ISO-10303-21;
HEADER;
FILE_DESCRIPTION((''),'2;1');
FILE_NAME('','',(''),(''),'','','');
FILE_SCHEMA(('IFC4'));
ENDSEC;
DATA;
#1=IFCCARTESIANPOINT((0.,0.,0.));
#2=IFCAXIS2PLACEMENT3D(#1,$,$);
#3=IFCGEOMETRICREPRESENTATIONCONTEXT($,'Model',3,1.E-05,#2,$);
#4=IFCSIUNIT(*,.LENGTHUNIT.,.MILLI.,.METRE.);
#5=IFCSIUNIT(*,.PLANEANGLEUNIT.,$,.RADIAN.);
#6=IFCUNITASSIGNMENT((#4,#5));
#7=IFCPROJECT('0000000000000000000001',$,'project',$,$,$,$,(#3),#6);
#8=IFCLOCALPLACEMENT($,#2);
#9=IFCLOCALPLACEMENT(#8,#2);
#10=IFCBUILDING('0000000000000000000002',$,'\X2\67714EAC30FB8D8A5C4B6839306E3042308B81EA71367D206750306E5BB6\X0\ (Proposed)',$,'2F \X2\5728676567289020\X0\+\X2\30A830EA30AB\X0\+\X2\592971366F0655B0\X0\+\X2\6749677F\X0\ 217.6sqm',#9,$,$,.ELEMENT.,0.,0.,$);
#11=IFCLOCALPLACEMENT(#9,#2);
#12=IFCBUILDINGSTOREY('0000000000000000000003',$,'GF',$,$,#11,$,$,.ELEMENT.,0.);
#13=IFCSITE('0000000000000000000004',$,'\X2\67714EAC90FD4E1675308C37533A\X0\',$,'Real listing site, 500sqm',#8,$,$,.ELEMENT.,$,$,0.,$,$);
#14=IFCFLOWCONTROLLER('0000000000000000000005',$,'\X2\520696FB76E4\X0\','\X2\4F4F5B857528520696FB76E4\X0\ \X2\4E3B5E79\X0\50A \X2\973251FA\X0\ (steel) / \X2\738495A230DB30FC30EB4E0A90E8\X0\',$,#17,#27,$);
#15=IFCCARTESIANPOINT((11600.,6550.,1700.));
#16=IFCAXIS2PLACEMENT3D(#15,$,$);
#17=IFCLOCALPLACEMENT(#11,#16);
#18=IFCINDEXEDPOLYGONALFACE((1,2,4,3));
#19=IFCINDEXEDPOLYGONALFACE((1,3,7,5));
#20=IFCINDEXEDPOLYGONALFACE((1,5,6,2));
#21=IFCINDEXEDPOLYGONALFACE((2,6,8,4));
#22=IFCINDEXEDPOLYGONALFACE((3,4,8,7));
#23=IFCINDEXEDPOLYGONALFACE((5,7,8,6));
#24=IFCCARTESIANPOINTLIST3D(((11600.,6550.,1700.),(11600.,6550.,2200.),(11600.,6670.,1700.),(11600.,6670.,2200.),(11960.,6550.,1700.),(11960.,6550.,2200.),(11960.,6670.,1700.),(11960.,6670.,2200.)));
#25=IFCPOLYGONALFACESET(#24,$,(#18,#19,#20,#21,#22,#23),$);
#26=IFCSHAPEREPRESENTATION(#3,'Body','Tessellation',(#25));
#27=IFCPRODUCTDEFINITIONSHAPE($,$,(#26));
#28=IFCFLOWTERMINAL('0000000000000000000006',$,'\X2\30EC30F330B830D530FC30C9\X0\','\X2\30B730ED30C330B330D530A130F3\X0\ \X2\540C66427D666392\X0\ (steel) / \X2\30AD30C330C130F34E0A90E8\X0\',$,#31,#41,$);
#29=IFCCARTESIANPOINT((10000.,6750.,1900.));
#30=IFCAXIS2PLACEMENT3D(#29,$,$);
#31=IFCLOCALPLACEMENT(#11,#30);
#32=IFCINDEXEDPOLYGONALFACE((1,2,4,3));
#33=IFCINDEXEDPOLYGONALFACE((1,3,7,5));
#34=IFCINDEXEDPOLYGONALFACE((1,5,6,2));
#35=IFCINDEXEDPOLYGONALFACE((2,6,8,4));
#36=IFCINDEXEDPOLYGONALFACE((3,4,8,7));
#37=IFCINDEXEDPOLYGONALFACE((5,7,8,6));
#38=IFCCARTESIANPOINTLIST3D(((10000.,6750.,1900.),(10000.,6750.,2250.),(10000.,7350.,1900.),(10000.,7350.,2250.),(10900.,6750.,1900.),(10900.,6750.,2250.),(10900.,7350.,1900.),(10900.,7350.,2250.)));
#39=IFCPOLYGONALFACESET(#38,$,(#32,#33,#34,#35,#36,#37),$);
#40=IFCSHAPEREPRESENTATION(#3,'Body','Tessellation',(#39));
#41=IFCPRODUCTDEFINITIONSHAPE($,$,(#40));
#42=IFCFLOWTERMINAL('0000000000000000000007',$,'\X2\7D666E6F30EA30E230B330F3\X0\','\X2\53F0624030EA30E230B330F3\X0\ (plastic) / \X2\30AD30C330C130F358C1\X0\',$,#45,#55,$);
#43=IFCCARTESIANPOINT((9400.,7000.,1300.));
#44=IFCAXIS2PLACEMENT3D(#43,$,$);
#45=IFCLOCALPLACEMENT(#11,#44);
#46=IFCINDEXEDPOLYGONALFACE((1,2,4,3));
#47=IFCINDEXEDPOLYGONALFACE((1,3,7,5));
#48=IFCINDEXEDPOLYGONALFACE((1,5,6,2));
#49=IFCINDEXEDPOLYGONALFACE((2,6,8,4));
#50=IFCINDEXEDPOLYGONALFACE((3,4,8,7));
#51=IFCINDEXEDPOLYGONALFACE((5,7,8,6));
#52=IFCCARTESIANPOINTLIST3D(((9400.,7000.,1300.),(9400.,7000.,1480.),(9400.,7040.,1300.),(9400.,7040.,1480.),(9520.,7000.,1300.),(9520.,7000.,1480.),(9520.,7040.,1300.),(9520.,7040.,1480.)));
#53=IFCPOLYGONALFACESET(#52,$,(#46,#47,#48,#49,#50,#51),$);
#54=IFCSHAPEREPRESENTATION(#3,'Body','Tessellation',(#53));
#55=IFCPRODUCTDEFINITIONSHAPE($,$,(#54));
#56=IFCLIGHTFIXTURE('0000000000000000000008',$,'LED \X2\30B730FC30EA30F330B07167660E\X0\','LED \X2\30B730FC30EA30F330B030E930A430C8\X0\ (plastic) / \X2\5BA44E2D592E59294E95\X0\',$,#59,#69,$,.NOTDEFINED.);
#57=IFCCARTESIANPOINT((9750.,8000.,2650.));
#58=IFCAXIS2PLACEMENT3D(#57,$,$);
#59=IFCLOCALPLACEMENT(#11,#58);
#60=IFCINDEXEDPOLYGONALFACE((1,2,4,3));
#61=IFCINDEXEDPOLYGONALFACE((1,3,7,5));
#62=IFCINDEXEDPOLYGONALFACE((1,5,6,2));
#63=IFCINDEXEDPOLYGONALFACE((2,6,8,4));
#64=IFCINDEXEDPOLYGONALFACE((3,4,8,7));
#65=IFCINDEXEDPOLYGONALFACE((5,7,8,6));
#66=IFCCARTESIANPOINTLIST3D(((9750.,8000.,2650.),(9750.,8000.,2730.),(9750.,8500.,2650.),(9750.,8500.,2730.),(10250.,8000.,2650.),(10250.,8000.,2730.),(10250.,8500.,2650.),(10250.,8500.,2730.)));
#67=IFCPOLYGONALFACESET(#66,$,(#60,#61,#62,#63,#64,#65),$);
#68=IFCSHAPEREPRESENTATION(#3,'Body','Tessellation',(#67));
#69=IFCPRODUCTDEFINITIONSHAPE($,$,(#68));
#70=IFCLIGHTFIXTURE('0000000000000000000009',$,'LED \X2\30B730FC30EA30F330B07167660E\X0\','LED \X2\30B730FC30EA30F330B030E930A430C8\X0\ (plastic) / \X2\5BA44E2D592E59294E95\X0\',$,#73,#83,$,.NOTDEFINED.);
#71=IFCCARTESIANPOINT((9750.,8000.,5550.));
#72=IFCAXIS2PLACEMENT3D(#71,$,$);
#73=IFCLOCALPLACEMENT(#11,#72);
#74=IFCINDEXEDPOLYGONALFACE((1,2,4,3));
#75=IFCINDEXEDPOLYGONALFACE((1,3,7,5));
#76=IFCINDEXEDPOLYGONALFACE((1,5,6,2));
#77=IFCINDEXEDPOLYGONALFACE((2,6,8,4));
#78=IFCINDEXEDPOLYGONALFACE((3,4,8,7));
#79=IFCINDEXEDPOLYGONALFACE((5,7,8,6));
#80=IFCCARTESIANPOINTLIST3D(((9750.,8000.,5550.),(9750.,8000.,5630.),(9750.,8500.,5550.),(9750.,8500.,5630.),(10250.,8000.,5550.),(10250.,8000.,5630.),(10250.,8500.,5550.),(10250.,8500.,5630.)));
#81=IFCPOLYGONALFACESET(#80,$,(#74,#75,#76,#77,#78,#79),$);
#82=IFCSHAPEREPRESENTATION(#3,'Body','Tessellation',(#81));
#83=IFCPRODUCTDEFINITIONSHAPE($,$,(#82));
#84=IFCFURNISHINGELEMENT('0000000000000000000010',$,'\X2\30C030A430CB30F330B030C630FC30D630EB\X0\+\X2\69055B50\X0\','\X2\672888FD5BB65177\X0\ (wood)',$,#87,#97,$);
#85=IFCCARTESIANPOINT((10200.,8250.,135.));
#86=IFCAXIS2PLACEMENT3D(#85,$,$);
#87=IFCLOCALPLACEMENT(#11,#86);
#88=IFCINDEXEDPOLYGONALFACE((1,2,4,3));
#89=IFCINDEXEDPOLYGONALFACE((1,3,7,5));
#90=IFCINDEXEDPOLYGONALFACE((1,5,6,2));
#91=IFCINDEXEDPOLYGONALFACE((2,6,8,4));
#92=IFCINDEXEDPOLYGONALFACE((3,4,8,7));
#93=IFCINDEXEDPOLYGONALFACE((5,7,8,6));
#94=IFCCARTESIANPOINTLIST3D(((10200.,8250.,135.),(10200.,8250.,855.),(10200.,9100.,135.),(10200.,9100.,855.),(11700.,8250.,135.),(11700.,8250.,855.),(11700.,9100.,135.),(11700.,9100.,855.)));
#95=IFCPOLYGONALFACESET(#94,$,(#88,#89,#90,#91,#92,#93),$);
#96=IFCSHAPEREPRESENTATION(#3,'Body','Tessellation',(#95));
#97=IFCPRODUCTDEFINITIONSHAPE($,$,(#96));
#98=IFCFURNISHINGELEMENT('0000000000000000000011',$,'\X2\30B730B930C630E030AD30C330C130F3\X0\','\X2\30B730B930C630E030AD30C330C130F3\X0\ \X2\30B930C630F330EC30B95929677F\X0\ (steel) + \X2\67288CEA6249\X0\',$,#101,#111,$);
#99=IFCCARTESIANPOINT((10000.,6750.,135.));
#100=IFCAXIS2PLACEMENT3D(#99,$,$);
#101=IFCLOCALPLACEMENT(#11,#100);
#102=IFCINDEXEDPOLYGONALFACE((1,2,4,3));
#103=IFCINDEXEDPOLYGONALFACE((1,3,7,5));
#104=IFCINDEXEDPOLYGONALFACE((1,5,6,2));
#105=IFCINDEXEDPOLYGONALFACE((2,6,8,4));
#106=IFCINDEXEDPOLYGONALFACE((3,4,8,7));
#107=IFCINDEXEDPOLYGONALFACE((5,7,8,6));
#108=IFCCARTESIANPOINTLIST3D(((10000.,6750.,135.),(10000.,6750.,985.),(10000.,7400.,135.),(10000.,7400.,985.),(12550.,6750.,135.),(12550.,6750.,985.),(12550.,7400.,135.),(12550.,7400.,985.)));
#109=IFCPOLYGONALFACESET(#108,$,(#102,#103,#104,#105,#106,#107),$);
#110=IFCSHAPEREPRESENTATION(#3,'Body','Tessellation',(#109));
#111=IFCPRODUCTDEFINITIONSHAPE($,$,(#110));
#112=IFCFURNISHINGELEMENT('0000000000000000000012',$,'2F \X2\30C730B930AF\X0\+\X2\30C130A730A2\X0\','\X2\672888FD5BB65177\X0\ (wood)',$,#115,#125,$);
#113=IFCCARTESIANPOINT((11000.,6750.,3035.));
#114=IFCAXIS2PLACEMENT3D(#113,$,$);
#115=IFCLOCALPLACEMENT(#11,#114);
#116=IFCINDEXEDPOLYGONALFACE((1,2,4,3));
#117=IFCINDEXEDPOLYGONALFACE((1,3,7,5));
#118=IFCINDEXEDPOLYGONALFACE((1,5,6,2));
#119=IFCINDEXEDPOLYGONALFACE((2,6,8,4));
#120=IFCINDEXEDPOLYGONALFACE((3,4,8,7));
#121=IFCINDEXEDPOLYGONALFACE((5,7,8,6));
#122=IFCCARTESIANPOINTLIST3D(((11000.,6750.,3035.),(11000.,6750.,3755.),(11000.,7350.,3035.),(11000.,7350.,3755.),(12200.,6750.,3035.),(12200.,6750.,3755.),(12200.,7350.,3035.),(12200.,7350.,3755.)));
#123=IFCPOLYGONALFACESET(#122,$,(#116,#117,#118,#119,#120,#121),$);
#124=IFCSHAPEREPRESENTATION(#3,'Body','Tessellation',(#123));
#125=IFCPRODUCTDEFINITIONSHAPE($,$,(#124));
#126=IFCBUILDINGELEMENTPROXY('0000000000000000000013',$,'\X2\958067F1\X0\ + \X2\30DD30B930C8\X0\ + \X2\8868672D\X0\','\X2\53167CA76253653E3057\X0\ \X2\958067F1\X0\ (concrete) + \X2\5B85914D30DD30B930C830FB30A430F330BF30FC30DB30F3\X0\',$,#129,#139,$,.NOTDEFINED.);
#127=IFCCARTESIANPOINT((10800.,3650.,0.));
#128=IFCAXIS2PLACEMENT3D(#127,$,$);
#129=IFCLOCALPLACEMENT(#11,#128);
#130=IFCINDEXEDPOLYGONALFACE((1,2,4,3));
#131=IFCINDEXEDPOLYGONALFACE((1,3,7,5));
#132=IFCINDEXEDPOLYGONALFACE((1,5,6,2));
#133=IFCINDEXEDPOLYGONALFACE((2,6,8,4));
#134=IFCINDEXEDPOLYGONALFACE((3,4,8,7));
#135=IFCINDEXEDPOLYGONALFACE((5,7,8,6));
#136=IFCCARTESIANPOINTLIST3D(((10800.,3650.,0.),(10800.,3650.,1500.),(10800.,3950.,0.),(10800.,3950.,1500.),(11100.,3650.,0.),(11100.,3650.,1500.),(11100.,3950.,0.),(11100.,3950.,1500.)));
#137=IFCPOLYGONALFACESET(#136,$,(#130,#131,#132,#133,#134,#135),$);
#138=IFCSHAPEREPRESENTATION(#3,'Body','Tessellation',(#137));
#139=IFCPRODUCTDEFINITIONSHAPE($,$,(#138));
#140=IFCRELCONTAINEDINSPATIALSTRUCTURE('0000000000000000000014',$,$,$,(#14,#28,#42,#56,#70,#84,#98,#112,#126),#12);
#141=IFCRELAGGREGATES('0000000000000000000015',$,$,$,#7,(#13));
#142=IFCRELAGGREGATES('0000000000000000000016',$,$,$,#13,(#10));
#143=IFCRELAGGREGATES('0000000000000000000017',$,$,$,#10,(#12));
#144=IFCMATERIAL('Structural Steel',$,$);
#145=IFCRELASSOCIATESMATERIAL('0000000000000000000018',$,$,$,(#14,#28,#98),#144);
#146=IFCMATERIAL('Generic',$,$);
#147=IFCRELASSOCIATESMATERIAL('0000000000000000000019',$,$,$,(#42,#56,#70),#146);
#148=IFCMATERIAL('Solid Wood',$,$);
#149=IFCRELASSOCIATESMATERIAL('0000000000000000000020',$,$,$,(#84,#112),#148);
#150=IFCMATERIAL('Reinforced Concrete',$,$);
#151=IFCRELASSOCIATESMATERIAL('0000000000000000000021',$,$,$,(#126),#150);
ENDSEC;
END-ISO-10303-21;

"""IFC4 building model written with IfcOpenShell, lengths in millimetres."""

from ifc_helpers import new_model, si_unit, frame, frame_2d, origin, place, context, project, spatial, rectangle, extrude, material, element, save


model = new_model("IFC4")

# Units and contexts
model_context = context("Model", 3, precision=1e-05, world=origin())
ifc_project = project(units=[si_unit("LENGTHUNIT", "METRE", prefix="MILLI"), si_unit("PLANEANGLEUNIT", "RADIAN")], contexts=[model_context])

# Site, building, storey
site_placement = place(None, origin())
site = spatial("IfcSite", under=ifc_project, at=site_placement, Name="東京都世田谷区", ObjectType="Real listing site, 500sqm", CompositionType="ELEMENT", RefElevation=0.0)
building_placement = place(site_placement, origin())
building = spatial("IfcBuilding", under=site, at=building_placement, Name="東京・越屋根のある自然素材の家 (Proposed)", ObjectType="2F 在来木造+エリカ+天然漆喰+杉板 217.6sqm", CompositionType="ELEMENT", ElevationOfRefHeight=0.0, ElevationOfTerrain=0.0)
storey_placement = place(building_placement, origin())
storey = spatial("IfcBuildingStorey", under=building, at=storey_placement, Name="GF", CompositionType="ELEMENT", Elevation=0.0)

# Shared definitions
ifc_material_1 = material(Name="Solid Wood")

# Shared definitions
ifc_material_2 = material(Name="Structural Steel")

# Shared definitions
ifc_material_3 = material(Name="Reinforced Concrete")

# Flow controller
flow_controller_placement = place(storey_placement, frame((11600.0, 6550.0, 1700.0)))
element("IfcFlowController", 1, at=flow_controller_placement, inside=storey, material=ifc_material_2, Name="分電盤", Description="住宅用分電盤 主幹50A 露出 (steel) / 玄関ホール上部", context=model_context, shape_type="SweptSolid", body=[
    extrude(rectangle(XDim=360.0, YDim=120.0, at=frame_2d((180.0, 60.0))), frame((11600.0, 6550.0, 1700.0)), (0.0, 0.0, 1.0), 500.0),
])

# Flow terminals
flow_terminal_1_placement = place(storey_placement, frame((10000.0, 6750.0, 1900.0)))
element("IfcFlowTerminal", 2, at=flow_terminal_1_placement, inside=storey, material=ifc_material_2, Name="レンジフード", Description="シロッコファン 同時給排 (steel) / キッチン上部", context=model_context, shape_type="SweptSolid", body=[
    extrude(rectangle(XDim=900.0, YDim=600.0, at=frame_2d((450.0, 300.0))), frame((10000.0, 6750.0, 1900.0)), (0.0, 0.0, 1.0), 350.0),
])
ifc_material_4 = material(Name="Generic")
flow_terminal_2_placement = place(storey_placement, frame((9400.0, 7000.0, 1300.0)))
element("IfcFlowTerminal", 3, at=flow_terminal_2_placement, inside=storey, material=ifc_material_4, Name="給湯リモコン", Description="台所リモコン (plastic) / キッチン壁", context=model_context, shape_type="SweptSolid", body=[
    extrude(rectangle(XDim=120.0, YDim=40.0, at=frame_2d((60.0, 20.0))), frame((9400.0, 7000.0, 1300.0)), (0.0, 0.0, 1.0), 180.0),
])

# Light fixtures
light_fixture_1_placement = place(storey_placement, frame((9750.0, 8000.0, 2650.0)))
element("IfcLightFixture", 4, at=light_fixture_1_placement, inside=storey, material=ifc_material_4, Name="LED シーリング照明", Description="LED シーリングライト (plastic) / 室中央天井", PredefinedType="NOTDEFINED", context=model_context, shape_type="SweptSolid", body=[
    extrude(rectangle(XDim=500.0, YDim=500.0, at=frame_2d((250.0, 250.0))), frame((9750.0, 8000.0, 2650.0)), (0.0, 0.0, 1.0), 80.0),
])
light_fixture_2_placement = place(storey_placement, frame((9750.0, 8000.0, 5550.0)))
element("IfcLightFixture", 5, at=light_fixture_2_placement, inside=storey, material=ifc_material_4, Name="LED シーリング照明", Description="LED シーリングライト (plastic) / 室中央天井", PredefinedType="NOTDEFINED", context=model_context, shape_type="SweptSolid", body=[
    extrude(rectangle(XDim=500.0, YDim=500.0, at=frame_2d((250.0, 250.0))), frame((9750.0, 8000.0, 5550.0)), (0.0, 0.0, 1.0), 80.0),
])

# Furnishing elements
furnishing_1_placement = place(storey_placement, frame((10200.0, 8250.0, 135.0)))
element("IfcFurnishingElement", 6, at=furnishing_1_placement, inside=storey, material=ifc_material_1, Name="ダイニングテーブル+椅子", Description="木製家具 (wood)", context=model_context, shape_type="SweptSolid", body=[
    extrude(rectangle(XDim=1500.0, YDim=850.0, at=frame_2d((750.0, 425.0))), frame((10200.0, 8250.0, 135.0)), (0.0, 0.0, 1.0), 720.0),
])
furnishing_2_placement = place(storey_placement, frame((10000.0, 6750.0, 135.0)))
element("IfcFurnishingElement", 7, at=furnishing_2_placement, inside=storey, material=ifc_material_2, Name="システムキッチン", Description="システムキッチン ステンレス天板 (steel) + 木質扉", context=model_context, shape_type="SweptSolid", body=[
    extrude(rectangle(XDim=2550.0, YDim=650.0, at=frame_2d((1275.0, 325.0))), frame((10000.0, 6750.0, 135.0)), (0.0, 0.0, 1.0), 850.0),
])
furnishing_3_placement = place(storey_placement, frame((11000.0, 6750.0, 3035.0)))
element("IfcFurnishingElement", 8, at=furnishing_3_placement, inside=storey, material=ifc_material_1, Name="2F デスク+チェア", Description="木製家具 (wood)", context=model_context, shape_type="SweptSolid", body=[
    extrude(rectangle(XDim=1200.0, YDim=600.0, at=frame_2d((600.0, 300.0))), frame((11000.0, 6750.0, 3035.0)), (0.0, 0.0, 1.0), 720.0),
])

# Building element proxy
proxy_placement = place(storey_placement, frame((10800.0, 3650.0, 0.0)))
element("IfcBuildingElementProxy", 9, at=proxy_placement, inside=storey, material=ifc_material_3, Name="門柱 + ポスト + 表札", Description="化粧打放し 門柱 (concrete) + 宅配ポスト・インターホン", PredefinedType="NOTDEFINED", context=model_context, shape_type="SweptSolid", body=[
    extrude(rectangle(XDim=300.0, YDim=300.0, at=frame_2d((150.0, 150.0))), frame((10800.0, 3650.0, 0.0)), (0.0, 0.0, 1.0), 1500.0),
])

save(model, "model.ifc")
